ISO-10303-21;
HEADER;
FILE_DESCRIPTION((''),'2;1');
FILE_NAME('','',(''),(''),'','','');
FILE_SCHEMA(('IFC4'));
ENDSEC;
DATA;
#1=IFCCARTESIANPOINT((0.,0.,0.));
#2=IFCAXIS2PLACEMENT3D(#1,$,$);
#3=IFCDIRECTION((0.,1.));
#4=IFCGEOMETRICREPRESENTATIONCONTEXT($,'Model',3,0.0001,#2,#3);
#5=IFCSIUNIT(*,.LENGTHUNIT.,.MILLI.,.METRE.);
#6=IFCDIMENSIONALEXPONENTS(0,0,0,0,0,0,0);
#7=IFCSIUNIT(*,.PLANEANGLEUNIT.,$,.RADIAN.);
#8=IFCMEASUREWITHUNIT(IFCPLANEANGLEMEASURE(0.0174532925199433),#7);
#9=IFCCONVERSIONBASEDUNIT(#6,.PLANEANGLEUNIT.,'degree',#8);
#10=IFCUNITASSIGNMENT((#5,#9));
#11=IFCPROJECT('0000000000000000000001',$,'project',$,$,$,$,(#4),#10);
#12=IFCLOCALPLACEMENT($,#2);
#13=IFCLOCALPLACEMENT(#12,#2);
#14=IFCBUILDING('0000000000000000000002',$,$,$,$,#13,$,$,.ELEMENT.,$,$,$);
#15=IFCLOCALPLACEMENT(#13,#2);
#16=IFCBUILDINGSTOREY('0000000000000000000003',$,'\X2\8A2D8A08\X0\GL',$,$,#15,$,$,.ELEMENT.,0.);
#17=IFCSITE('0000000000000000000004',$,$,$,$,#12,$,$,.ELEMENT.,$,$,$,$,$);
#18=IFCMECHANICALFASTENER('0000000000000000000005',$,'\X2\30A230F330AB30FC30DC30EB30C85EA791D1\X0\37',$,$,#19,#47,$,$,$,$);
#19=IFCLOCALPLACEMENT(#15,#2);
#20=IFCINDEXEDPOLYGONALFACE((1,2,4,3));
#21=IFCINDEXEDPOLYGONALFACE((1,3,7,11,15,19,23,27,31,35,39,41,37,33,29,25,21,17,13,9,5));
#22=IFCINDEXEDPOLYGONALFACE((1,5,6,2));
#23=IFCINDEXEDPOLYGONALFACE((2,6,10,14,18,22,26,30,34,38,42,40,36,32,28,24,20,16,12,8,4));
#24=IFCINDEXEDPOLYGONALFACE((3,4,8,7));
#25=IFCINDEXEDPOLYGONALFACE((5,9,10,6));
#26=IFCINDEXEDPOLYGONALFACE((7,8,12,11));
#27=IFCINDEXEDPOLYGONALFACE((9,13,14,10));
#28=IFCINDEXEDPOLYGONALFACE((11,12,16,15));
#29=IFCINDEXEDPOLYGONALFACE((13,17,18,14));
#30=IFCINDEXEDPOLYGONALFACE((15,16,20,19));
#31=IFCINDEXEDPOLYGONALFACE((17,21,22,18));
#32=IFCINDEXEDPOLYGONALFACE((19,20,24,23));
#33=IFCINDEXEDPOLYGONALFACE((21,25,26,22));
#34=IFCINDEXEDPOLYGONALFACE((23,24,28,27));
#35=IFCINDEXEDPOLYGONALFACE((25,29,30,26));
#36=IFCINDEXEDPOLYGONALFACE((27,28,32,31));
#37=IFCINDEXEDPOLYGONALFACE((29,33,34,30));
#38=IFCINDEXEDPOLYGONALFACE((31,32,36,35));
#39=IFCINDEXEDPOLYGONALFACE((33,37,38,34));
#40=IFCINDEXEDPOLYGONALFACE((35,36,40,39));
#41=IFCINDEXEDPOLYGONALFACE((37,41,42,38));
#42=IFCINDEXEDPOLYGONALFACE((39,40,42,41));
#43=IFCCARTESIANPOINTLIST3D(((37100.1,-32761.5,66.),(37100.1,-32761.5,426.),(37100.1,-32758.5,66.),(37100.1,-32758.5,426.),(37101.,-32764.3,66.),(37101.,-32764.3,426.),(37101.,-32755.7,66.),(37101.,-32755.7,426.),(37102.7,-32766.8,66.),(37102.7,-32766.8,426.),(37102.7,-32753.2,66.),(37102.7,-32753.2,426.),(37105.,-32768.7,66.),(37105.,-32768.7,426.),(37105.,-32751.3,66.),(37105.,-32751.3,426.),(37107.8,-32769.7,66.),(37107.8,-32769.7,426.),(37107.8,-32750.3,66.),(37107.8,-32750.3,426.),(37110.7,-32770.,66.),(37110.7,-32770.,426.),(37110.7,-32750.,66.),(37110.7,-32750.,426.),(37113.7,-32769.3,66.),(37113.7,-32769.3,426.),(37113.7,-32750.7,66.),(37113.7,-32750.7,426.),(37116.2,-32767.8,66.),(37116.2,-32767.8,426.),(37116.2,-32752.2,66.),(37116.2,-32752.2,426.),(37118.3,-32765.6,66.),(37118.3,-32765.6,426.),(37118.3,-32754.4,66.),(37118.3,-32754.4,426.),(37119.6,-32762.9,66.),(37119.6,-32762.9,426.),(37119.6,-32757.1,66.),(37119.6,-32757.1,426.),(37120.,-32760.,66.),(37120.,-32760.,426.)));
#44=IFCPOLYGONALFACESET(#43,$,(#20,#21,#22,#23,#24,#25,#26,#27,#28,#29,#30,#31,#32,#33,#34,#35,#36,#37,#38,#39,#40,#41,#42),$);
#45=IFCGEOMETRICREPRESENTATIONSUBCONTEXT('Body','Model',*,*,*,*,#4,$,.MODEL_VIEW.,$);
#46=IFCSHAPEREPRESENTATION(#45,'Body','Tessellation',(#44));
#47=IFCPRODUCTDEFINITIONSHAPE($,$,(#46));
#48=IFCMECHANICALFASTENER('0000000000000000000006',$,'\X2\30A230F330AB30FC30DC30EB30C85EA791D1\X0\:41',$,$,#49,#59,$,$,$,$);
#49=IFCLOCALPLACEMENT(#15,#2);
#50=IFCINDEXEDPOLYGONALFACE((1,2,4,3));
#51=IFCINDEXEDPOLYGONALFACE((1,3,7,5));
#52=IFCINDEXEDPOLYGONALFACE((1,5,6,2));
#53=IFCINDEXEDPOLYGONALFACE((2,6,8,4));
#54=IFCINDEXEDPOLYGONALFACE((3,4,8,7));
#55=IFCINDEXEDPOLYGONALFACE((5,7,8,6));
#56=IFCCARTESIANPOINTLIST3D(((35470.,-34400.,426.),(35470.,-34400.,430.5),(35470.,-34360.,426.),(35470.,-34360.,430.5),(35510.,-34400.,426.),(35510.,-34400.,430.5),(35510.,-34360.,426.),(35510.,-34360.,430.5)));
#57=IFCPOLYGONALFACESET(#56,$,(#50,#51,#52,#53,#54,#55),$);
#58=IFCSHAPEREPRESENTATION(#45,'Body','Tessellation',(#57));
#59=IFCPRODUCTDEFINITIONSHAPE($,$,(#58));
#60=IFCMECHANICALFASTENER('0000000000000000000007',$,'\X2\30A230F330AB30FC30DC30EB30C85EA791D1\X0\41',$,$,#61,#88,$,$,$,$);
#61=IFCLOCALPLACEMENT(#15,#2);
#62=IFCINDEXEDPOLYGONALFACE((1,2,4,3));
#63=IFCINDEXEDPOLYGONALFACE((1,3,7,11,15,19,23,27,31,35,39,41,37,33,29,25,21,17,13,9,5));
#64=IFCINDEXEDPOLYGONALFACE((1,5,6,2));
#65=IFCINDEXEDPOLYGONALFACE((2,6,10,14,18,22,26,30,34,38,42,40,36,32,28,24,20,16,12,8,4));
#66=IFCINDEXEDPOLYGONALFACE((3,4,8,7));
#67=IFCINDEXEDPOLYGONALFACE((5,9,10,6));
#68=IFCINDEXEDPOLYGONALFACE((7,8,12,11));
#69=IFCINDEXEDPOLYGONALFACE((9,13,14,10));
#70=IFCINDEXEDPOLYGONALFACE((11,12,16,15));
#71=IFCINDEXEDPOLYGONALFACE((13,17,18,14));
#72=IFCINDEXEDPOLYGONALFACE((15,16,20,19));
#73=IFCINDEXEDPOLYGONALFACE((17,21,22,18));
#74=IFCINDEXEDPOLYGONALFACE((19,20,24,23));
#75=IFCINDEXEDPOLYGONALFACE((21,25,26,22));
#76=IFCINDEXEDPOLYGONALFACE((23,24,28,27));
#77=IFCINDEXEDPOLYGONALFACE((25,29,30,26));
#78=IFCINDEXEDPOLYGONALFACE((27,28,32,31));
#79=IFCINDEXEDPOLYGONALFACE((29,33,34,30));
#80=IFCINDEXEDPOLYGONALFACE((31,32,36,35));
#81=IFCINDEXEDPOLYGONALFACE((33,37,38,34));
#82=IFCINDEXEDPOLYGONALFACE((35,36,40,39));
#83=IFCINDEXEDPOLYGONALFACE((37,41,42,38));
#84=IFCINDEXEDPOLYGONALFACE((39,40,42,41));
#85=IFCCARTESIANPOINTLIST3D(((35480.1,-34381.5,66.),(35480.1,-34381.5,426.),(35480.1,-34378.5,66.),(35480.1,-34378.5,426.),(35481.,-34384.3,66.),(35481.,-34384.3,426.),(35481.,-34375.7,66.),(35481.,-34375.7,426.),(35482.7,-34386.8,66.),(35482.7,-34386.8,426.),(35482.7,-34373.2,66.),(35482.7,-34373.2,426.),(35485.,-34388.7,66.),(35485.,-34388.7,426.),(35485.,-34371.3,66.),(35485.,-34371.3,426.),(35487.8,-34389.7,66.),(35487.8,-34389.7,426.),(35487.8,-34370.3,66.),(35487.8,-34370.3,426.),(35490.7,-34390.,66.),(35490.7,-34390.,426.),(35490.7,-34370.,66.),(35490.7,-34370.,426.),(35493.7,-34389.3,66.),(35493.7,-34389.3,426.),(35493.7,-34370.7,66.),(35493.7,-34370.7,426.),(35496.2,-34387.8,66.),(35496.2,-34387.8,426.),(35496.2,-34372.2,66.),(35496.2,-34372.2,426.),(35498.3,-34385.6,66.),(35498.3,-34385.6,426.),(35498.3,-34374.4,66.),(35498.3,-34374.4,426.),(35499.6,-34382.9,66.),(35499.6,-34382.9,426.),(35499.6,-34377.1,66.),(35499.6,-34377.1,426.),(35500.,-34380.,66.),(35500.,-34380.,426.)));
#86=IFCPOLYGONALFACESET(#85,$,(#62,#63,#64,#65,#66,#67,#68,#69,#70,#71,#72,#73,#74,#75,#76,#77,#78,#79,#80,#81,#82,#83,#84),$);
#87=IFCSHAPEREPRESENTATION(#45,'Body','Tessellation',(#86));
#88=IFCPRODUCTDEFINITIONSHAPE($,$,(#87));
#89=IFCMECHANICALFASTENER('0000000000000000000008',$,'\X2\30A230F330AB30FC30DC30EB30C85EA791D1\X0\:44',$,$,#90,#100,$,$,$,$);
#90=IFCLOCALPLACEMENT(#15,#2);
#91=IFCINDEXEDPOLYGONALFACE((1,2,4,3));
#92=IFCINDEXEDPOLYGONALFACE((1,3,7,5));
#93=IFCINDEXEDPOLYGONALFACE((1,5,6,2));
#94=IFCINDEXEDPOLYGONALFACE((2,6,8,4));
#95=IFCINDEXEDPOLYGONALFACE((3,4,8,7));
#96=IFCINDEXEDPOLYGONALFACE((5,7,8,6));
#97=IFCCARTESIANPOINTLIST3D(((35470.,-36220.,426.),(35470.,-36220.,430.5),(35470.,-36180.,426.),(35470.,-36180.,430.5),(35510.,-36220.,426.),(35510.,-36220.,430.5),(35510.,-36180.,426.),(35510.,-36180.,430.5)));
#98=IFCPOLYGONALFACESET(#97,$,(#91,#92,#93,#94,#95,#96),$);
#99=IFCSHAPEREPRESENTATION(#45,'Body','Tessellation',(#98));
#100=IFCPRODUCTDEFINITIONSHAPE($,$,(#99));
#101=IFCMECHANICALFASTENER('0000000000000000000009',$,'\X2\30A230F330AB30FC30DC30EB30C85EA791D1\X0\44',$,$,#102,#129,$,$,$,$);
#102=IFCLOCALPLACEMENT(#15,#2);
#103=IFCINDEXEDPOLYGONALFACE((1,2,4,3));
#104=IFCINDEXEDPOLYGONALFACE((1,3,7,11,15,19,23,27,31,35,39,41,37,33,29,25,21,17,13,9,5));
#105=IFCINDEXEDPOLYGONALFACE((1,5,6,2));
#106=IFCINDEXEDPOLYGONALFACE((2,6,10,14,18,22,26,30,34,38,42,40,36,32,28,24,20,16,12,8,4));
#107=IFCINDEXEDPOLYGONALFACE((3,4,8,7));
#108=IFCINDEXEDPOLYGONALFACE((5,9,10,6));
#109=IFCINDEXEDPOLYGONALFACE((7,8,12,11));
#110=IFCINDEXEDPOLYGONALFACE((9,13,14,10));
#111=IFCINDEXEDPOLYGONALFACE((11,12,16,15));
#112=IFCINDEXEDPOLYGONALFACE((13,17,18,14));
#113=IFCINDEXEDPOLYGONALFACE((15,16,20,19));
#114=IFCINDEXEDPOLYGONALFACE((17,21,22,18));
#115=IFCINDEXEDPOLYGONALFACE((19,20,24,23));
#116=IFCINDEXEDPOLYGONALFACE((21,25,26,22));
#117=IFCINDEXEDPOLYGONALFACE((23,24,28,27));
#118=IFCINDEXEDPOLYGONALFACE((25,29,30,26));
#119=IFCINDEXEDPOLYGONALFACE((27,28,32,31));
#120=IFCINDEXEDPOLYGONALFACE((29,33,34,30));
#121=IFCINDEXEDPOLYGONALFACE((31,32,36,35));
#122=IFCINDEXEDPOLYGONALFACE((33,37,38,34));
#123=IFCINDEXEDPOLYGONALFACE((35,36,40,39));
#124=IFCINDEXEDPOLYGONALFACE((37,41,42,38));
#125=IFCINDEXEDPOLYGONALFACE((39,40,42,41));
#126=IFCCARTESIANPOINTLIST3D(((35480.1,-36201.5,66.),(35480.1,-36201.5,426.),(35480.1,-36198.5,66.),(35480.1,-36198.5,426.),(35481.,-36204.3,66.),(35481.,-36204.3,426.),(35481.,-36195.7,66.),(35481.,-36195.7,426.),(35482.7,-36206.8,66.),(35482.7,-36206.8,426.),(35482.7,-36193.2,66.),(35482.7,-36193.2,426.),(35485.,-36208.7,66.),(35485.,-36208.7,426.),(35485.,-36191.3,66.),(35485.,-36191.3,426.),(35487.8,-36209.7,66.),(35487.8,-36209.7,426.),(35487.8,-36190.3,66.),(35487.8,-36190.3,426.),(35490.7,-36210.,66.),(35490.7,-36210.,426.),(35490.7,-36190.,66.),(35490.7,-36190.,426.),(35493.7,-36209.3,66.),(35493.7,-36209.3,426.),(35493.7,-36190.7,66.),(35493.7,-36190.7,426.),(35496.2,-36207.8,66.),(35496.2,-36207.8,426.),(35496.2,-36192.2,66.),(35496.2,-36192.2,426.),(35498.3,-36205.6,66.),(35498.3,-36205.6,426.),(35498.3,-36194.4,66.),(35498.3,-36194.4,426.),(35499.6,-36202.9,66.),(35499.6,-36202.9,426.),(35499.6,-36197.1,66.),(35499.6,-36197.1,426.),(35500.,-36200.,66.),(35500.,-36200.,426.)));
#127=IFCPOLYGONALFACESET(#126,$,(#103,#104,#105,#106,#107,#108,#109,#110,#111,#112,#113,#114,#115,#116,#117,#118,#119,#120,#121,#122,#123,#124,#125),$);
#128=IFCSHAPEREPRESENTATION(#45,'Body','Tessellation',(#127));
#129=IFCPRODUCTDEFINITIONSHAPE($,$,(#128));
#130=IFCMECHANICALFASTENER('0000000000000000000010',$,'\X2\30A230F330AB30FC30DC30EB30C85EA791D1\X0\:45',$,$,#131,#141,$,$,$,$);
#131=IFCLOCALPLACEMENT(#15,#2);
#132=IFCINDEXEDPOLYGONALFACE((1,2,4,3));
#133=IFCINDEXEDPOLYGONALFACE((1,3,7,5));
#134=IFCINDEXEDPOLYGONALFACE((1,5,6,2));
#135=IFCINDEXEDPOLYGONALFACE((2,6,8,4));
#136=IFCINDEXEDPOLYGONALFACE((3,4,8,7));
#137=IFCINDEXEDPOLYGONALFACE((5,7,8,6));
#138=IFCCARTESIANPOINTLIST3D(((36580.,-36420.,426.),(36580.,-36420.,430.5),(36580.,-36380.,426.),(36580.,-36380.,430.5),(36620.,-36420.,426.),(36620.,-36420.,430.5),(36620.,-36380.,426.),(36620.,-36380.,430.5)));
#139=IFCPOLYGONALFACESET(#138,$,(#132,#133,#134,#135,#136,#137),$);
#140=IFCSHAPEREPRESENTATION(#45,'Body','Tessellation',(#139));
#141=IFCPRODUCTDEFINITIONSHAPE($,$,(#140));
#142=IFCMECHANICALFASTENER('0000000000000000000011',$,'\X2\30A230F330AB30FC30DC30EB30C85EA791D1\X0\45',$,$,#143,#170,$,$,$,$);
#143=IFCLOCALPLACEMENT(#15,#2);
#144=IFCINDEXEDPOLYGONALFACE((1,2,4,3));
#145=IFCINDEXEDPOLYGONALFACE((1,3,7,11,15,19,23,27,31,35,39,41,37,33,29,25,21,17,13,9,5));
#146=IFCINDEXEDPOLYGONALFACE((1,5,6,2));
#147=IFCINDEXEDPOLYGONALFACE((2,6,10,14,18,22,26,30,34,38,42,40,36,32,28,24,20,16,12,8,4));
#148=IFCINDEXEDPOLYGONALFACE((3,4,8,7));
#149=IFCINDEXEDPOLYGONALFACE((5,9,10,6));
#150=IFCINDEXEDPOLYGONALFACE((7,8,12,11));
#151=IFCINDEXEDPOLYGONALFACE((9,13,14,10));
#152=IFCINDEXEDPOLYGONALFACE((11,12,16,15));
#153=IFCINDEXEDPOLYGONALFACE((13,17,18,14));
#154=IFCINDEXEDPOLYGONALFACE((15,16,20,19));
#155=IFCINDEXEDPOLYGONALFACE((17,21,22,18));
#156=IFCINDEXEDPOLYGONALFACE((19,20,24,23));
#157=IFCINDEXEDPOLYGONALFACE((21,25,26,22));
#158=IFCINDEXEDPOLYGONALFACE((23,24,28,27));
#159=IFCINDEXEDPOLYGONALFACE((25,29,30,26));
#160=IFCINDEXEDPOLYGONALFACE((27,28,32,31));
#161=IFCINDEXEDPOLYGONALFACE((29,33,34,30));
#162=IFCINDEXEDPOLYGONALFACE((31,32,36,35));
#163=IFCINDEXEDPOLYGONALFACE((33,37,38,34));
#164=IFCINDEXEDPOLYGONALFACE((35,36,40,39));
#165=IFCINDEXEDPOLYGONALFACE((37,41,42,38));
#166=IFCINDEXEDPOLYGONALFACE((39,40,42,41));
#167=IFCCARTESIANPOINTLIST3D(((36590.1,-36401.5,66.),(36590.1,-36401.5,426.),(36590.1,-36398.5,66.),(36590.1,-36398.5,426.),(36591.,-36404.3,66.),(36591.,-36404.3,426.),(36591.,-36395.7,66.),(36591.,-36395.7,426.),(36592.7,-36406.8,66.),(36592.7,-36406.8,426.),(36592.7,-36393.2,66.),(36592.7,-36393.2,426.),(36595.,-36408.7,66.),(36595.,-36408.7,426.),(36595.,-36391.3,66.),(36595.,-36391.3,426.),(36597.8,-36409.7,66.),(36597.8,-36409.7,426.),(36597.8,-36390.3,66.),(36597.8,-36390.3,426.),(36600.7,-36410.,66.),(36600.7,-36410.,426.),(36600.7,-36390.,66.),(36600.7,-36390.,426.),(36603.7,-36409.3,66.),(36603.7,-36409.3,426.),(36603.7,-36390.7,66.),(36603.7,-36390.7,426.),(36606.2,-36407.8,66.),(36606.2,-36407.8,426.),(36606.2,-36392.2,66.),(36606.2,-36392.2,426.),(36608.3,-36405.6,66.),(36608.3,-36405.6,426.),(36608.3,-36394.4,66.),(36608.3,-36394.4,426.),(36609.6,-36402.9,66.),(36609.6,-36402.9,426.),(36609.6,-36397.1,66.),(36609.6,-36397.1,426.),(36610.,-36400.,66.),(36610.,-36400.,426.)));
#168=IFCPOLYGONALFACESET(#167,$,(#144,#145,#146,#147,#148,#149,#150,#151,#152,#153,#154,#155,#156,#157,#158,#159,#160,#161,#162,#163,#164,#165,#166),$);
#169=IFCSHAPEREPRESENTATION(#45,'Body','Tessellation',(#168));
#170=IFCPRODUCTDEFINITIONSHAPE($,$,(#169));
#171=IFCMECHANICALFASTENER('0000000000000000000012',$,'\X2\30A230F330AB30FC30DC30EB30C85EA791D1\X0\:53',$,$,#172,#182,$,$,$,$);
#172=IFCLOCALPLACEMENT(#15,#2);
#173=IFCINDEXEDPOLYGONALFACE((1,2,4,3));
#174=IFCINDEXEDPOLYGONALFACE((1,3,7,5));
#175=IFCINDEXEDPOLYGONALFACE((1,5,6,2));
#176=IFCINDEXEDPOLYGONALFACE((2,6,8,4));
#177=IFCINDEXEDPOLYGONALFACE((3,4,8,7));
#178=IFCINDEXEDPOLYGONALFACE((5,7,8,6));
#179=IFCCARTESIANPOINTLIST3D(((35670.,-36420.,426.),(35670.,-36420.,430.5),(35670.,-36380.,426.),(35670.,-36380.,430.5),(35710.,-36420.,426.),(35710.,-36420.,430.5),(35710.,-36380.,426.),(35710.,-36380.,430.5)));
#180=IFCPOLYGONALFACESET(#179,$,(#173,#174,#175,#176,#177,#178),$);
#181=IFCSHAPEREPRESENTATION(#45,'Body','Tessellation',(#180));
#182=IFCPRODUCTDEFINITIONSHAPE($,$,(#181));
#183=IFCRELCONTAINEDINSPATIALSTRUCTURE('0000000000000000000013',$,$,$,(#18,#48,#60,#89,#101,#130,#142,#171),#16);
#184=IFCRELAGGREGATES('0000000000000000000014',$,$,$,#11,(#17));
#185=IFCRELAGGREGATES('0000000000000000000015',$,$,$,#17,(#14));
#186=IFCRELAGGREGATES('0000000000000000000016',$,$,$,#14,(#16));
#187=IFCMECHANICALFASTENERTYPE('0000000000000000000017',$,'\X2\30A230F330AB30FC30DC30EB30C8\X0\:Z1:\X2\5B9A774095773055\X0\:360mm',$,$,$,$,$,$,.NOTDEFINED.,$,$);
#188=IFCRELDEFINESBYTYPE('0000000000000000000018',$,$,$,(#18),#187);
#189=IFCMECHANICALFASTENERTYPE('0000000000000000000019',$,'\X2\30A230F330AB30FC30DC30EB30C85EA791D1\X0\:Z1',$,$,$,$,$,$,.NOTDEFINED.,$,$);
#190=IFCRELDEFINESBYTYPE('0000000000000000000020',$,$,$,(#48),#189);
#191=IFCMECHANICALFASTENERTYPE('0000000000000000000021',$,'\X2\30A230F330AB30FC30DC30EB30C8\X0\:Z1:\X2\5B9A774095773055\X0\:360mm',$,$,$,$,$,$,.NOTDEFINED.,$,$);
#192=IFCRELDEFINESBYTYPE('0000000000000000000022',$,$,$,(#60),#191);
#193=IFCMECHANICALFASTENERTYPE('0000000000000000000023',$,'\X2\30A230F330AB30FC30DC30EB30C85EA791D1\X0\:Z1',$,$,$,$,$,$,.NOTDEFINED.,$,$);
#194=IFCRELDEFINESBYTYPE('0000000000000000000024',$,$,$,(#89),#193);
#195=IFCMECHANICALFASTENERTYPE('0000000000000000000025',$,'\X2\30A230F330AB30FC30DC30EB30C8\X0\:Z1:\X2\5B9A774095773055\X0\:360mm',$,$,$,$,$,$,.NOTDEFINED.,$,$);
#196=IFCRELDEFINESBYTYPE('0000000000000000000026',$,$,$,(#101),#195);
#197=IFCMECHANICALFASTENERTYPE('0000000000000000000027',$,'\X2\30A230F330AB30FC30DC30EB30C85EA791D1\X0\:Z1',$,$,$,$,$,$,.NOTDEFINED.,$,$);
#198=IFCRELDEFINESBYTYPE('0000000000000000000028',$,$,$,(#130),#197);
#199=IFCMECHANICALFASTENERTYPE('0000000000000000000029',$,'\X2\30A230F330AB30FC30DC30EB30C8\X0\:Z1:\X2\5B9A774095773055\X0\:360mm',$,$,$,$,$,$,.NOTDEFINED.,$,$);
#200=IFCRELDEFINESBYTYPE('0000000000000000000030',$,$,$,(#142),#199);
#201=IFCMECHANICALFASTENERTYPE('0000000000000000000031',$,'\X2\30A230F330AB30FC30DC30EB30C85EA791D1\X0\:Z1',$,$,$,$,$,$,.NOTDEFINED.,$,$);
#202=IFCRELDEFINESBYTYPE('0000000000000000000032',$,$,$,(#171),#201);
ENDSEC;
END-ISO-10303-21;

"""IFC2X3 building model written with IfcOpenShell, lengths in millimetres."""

from ifc_helpers import new_model, entity, si_unit, converted_unit, direction, frame, origin, origin_with_axes, origin_2d, place, context, subcontext, project, spatial, rectangle, circle, extrude, type_object, element, save


model = new_model("IFC2X3")

# Units and contexts
model_context = context("Model", 3, precision=0.0001, world=origin(), true_north=direction((0.0, 1.0)))
body_context = subcontext(model_context, "Body", "Model", "MODEL_VIEW")
ifc_project = project(units=[si_unit("LENGTHUNIT", "METRE", prefix="MILLI"), converted_unit("PLANEANGLEUNIT", "degree", entity("IfcPlaneAngleMeasure", 0.0174532925199433), si_unit("PLANEANGLEUNIT", "RADIAN"), dimensions=[0, 0, 0, 0, 0, 0, 0])], contexts=[model_context])

# Site, building, storey
site_placement = place(None, origin())
site = spatial("IfcSite", under=ifc_project, at=site_placement, CompositionType="ELEMENT")
building_placement = place(site_placement, origin())
building = spatial("IfcBuilding", under=site, at=building_placement, CompositionType="ELEMENT")
storey_placement = place(building_placement, origin())
storey = spatial("IfcBuildingStorey", under=building, at=storey_placement, Name="設計GL", CompositionType="ELEMENT", Elevation=0.0)

# Mechanical fasteners
mechanical_fastener_type_1 = type_object("IfcMechanicalFastenerType", Name="アンカーボルト:Z1:定着長さ:360mm")
mechanical_fastener_1_placement = place(storey_placement, frame((37110.0, -32760.0, 66.0)))
element("IfcMechanicalFastener", 1, at=mechanical_fastener_1_placement, inside=storey, type_object=mechanical_fastener_type_1, Name="アンカーボルト座金37", context=body_context, shape_type="SweptSolid", body=[
    extrude(circle(Radius=10.0, at=origin_2d()), origin_with_axes(), (0.0, 0.0, 1.0), 360.0),
])
mechanical_fastener_type_2 = type_object("IfcMechanicalFastenerType", Name="アンカーボルト座金:Z1")
mechanical_fastener_2_placement = place(storey_placement, frame((35490.0, -34380.0, 426.0)))
element("IfcMechanicalFastener", 2, at=mechanical_fastener_2_placement, inside=storey, type_object=mechanical_fastener_type_2, Name="アンカーボルト座金:41", context=body_context, shape_type="SweptSolid", body=[
    extrude(rectangle(XDim=40.0, YDim=40.0, at=origin_2d()), origin_with_axes(), (0.0, 0.0, 1.0), 4.5),
])
mechanical_fastener_type_3 = type_object("IfcMechanicalFastenerType", Name="アンカーボルト:Z1:定着長さ:360mm")
mechanical_fastener_3_placement = place(storey_placement, frame((35490.0, -34380.0, 66.0)))
element("IfcMechanicalFastener", 3, at=mechanical_fastener_3_placement, inside=storey, type_object=mechanical_fastener_type_3, Name="アンカーボルト座金41", context=body_context, shape_type="SweptSolid", body=[
    extrude(circle(Radius=10.0, at=origin_2d()), origin_with_axes(), (0.0, 0.0, 1.0), 360.0),
])
mechanical_fastener_type_4 = type_object("IfcMechanicalFastenerType", Name="アンカーボルト座金:Z1")
mechanical_fastener_4_placement = place(storey_placement, frame((35490.0, -36200.0, 426.0)))
element("IfcMechanicalFastener", 4, at=mechanical_fastener_4_placement, inside=storey, type_object=mechanical_fastener_type_4, Name="アンカーボルト座金:44", context=body_context, shape_type="SweptSolid", body=[
    extrude(rectangle(XDim=40.0, YDim=40.0, at=origin_2d()), origin_with_axes(), (0.0, 0.0, 1.0), 4.5),
])
mechanical_fastener_type_5 = type_object("IfcMechanicalFastenerType", Name="アンカーボルト:Z1:定着長さ:360mm")
mechanical_fastener_5_placement = place(storey_placement, frame((35490.0, -36200.0, 66.0)))
element("IfcMechanicalFastener", 5, at=mechanical_fastener_5_placement, inside=storey, type_object=mechanical_fastener_type_5, Name="アンカーボルト座金44", context=body_context, shape_type="SweptSolid", body=[
    extrude(circle(Radius=10.0, at=origin_2d()), origin_with_axes(), (0.0, 0.0, 1.0), 360.0),
])
mechanical_fastener_type_6 = type_object("IfcMechanicalFastenerType", Name="アンカーボルト座金:Z1")
mechanical_fastener_6_placement = place(storey_placement, frame((36600.0, -36400.0, 426.0)))
element("IfcMechanicalFastener", 6, at=mechanical_fastener_6_placement, inside=storey, type_object=mechanical_fastener_type_6, Name="アンカーボルト座金:45", context=body_context, shape_type="SweptSolid", body=[
    extrude(rectangle(XDim=40.0, YDim=40.0, at=origin_2d()), origin_with_axes(), (0.0, 0.0, 1.0), 4.5),
])
mechanical_fastener_type_7 = type_object("IfcMechanicalFastenerType", Name="アンカーボルト:Z1:定着長さ:360mm")
mechanical_fastener_7_placement = place(storey_placement, frame((36600.0, -36400.0, 66.0)))
element("IfcMechanicalFastener", 7, at=mechanical_fastener_7_placement, inside=storey, type_object=mechanical_fastener_type_7, Name="アンカーボルト座金45", context=body_context, shape_type="SweptSolid", body=[
    extrude(circle(Radius=10.0, at=origin_2d()), origin_with_axes(), (0.0, 0.0, 1.0), 360.0),
])
mechanical_fastener_type_8 = type_object("IfcMechanicalFastenerType", Name="アンカーボルト座金:Z1")
mechanical_fastener_8_placement = place(storey_placement, frame((35690.0, -36400.0, 426.0)))
element("IfcMechanicalFastener", 8, at=mechanical_fastener_8_placement, inside=storey, type_object=mechanical_fastener_type_8, Name="アンカーボルト座金:53", context=body_context, shape_type="SweptSolid", body=[
    extrude(rectangle(XDim=40.0, YDim=40.0, at=origin_2d()), origin_with_axes(), (0.0, 0.0, 1.0), 4.5),
])

save(model, "model.ifc")
